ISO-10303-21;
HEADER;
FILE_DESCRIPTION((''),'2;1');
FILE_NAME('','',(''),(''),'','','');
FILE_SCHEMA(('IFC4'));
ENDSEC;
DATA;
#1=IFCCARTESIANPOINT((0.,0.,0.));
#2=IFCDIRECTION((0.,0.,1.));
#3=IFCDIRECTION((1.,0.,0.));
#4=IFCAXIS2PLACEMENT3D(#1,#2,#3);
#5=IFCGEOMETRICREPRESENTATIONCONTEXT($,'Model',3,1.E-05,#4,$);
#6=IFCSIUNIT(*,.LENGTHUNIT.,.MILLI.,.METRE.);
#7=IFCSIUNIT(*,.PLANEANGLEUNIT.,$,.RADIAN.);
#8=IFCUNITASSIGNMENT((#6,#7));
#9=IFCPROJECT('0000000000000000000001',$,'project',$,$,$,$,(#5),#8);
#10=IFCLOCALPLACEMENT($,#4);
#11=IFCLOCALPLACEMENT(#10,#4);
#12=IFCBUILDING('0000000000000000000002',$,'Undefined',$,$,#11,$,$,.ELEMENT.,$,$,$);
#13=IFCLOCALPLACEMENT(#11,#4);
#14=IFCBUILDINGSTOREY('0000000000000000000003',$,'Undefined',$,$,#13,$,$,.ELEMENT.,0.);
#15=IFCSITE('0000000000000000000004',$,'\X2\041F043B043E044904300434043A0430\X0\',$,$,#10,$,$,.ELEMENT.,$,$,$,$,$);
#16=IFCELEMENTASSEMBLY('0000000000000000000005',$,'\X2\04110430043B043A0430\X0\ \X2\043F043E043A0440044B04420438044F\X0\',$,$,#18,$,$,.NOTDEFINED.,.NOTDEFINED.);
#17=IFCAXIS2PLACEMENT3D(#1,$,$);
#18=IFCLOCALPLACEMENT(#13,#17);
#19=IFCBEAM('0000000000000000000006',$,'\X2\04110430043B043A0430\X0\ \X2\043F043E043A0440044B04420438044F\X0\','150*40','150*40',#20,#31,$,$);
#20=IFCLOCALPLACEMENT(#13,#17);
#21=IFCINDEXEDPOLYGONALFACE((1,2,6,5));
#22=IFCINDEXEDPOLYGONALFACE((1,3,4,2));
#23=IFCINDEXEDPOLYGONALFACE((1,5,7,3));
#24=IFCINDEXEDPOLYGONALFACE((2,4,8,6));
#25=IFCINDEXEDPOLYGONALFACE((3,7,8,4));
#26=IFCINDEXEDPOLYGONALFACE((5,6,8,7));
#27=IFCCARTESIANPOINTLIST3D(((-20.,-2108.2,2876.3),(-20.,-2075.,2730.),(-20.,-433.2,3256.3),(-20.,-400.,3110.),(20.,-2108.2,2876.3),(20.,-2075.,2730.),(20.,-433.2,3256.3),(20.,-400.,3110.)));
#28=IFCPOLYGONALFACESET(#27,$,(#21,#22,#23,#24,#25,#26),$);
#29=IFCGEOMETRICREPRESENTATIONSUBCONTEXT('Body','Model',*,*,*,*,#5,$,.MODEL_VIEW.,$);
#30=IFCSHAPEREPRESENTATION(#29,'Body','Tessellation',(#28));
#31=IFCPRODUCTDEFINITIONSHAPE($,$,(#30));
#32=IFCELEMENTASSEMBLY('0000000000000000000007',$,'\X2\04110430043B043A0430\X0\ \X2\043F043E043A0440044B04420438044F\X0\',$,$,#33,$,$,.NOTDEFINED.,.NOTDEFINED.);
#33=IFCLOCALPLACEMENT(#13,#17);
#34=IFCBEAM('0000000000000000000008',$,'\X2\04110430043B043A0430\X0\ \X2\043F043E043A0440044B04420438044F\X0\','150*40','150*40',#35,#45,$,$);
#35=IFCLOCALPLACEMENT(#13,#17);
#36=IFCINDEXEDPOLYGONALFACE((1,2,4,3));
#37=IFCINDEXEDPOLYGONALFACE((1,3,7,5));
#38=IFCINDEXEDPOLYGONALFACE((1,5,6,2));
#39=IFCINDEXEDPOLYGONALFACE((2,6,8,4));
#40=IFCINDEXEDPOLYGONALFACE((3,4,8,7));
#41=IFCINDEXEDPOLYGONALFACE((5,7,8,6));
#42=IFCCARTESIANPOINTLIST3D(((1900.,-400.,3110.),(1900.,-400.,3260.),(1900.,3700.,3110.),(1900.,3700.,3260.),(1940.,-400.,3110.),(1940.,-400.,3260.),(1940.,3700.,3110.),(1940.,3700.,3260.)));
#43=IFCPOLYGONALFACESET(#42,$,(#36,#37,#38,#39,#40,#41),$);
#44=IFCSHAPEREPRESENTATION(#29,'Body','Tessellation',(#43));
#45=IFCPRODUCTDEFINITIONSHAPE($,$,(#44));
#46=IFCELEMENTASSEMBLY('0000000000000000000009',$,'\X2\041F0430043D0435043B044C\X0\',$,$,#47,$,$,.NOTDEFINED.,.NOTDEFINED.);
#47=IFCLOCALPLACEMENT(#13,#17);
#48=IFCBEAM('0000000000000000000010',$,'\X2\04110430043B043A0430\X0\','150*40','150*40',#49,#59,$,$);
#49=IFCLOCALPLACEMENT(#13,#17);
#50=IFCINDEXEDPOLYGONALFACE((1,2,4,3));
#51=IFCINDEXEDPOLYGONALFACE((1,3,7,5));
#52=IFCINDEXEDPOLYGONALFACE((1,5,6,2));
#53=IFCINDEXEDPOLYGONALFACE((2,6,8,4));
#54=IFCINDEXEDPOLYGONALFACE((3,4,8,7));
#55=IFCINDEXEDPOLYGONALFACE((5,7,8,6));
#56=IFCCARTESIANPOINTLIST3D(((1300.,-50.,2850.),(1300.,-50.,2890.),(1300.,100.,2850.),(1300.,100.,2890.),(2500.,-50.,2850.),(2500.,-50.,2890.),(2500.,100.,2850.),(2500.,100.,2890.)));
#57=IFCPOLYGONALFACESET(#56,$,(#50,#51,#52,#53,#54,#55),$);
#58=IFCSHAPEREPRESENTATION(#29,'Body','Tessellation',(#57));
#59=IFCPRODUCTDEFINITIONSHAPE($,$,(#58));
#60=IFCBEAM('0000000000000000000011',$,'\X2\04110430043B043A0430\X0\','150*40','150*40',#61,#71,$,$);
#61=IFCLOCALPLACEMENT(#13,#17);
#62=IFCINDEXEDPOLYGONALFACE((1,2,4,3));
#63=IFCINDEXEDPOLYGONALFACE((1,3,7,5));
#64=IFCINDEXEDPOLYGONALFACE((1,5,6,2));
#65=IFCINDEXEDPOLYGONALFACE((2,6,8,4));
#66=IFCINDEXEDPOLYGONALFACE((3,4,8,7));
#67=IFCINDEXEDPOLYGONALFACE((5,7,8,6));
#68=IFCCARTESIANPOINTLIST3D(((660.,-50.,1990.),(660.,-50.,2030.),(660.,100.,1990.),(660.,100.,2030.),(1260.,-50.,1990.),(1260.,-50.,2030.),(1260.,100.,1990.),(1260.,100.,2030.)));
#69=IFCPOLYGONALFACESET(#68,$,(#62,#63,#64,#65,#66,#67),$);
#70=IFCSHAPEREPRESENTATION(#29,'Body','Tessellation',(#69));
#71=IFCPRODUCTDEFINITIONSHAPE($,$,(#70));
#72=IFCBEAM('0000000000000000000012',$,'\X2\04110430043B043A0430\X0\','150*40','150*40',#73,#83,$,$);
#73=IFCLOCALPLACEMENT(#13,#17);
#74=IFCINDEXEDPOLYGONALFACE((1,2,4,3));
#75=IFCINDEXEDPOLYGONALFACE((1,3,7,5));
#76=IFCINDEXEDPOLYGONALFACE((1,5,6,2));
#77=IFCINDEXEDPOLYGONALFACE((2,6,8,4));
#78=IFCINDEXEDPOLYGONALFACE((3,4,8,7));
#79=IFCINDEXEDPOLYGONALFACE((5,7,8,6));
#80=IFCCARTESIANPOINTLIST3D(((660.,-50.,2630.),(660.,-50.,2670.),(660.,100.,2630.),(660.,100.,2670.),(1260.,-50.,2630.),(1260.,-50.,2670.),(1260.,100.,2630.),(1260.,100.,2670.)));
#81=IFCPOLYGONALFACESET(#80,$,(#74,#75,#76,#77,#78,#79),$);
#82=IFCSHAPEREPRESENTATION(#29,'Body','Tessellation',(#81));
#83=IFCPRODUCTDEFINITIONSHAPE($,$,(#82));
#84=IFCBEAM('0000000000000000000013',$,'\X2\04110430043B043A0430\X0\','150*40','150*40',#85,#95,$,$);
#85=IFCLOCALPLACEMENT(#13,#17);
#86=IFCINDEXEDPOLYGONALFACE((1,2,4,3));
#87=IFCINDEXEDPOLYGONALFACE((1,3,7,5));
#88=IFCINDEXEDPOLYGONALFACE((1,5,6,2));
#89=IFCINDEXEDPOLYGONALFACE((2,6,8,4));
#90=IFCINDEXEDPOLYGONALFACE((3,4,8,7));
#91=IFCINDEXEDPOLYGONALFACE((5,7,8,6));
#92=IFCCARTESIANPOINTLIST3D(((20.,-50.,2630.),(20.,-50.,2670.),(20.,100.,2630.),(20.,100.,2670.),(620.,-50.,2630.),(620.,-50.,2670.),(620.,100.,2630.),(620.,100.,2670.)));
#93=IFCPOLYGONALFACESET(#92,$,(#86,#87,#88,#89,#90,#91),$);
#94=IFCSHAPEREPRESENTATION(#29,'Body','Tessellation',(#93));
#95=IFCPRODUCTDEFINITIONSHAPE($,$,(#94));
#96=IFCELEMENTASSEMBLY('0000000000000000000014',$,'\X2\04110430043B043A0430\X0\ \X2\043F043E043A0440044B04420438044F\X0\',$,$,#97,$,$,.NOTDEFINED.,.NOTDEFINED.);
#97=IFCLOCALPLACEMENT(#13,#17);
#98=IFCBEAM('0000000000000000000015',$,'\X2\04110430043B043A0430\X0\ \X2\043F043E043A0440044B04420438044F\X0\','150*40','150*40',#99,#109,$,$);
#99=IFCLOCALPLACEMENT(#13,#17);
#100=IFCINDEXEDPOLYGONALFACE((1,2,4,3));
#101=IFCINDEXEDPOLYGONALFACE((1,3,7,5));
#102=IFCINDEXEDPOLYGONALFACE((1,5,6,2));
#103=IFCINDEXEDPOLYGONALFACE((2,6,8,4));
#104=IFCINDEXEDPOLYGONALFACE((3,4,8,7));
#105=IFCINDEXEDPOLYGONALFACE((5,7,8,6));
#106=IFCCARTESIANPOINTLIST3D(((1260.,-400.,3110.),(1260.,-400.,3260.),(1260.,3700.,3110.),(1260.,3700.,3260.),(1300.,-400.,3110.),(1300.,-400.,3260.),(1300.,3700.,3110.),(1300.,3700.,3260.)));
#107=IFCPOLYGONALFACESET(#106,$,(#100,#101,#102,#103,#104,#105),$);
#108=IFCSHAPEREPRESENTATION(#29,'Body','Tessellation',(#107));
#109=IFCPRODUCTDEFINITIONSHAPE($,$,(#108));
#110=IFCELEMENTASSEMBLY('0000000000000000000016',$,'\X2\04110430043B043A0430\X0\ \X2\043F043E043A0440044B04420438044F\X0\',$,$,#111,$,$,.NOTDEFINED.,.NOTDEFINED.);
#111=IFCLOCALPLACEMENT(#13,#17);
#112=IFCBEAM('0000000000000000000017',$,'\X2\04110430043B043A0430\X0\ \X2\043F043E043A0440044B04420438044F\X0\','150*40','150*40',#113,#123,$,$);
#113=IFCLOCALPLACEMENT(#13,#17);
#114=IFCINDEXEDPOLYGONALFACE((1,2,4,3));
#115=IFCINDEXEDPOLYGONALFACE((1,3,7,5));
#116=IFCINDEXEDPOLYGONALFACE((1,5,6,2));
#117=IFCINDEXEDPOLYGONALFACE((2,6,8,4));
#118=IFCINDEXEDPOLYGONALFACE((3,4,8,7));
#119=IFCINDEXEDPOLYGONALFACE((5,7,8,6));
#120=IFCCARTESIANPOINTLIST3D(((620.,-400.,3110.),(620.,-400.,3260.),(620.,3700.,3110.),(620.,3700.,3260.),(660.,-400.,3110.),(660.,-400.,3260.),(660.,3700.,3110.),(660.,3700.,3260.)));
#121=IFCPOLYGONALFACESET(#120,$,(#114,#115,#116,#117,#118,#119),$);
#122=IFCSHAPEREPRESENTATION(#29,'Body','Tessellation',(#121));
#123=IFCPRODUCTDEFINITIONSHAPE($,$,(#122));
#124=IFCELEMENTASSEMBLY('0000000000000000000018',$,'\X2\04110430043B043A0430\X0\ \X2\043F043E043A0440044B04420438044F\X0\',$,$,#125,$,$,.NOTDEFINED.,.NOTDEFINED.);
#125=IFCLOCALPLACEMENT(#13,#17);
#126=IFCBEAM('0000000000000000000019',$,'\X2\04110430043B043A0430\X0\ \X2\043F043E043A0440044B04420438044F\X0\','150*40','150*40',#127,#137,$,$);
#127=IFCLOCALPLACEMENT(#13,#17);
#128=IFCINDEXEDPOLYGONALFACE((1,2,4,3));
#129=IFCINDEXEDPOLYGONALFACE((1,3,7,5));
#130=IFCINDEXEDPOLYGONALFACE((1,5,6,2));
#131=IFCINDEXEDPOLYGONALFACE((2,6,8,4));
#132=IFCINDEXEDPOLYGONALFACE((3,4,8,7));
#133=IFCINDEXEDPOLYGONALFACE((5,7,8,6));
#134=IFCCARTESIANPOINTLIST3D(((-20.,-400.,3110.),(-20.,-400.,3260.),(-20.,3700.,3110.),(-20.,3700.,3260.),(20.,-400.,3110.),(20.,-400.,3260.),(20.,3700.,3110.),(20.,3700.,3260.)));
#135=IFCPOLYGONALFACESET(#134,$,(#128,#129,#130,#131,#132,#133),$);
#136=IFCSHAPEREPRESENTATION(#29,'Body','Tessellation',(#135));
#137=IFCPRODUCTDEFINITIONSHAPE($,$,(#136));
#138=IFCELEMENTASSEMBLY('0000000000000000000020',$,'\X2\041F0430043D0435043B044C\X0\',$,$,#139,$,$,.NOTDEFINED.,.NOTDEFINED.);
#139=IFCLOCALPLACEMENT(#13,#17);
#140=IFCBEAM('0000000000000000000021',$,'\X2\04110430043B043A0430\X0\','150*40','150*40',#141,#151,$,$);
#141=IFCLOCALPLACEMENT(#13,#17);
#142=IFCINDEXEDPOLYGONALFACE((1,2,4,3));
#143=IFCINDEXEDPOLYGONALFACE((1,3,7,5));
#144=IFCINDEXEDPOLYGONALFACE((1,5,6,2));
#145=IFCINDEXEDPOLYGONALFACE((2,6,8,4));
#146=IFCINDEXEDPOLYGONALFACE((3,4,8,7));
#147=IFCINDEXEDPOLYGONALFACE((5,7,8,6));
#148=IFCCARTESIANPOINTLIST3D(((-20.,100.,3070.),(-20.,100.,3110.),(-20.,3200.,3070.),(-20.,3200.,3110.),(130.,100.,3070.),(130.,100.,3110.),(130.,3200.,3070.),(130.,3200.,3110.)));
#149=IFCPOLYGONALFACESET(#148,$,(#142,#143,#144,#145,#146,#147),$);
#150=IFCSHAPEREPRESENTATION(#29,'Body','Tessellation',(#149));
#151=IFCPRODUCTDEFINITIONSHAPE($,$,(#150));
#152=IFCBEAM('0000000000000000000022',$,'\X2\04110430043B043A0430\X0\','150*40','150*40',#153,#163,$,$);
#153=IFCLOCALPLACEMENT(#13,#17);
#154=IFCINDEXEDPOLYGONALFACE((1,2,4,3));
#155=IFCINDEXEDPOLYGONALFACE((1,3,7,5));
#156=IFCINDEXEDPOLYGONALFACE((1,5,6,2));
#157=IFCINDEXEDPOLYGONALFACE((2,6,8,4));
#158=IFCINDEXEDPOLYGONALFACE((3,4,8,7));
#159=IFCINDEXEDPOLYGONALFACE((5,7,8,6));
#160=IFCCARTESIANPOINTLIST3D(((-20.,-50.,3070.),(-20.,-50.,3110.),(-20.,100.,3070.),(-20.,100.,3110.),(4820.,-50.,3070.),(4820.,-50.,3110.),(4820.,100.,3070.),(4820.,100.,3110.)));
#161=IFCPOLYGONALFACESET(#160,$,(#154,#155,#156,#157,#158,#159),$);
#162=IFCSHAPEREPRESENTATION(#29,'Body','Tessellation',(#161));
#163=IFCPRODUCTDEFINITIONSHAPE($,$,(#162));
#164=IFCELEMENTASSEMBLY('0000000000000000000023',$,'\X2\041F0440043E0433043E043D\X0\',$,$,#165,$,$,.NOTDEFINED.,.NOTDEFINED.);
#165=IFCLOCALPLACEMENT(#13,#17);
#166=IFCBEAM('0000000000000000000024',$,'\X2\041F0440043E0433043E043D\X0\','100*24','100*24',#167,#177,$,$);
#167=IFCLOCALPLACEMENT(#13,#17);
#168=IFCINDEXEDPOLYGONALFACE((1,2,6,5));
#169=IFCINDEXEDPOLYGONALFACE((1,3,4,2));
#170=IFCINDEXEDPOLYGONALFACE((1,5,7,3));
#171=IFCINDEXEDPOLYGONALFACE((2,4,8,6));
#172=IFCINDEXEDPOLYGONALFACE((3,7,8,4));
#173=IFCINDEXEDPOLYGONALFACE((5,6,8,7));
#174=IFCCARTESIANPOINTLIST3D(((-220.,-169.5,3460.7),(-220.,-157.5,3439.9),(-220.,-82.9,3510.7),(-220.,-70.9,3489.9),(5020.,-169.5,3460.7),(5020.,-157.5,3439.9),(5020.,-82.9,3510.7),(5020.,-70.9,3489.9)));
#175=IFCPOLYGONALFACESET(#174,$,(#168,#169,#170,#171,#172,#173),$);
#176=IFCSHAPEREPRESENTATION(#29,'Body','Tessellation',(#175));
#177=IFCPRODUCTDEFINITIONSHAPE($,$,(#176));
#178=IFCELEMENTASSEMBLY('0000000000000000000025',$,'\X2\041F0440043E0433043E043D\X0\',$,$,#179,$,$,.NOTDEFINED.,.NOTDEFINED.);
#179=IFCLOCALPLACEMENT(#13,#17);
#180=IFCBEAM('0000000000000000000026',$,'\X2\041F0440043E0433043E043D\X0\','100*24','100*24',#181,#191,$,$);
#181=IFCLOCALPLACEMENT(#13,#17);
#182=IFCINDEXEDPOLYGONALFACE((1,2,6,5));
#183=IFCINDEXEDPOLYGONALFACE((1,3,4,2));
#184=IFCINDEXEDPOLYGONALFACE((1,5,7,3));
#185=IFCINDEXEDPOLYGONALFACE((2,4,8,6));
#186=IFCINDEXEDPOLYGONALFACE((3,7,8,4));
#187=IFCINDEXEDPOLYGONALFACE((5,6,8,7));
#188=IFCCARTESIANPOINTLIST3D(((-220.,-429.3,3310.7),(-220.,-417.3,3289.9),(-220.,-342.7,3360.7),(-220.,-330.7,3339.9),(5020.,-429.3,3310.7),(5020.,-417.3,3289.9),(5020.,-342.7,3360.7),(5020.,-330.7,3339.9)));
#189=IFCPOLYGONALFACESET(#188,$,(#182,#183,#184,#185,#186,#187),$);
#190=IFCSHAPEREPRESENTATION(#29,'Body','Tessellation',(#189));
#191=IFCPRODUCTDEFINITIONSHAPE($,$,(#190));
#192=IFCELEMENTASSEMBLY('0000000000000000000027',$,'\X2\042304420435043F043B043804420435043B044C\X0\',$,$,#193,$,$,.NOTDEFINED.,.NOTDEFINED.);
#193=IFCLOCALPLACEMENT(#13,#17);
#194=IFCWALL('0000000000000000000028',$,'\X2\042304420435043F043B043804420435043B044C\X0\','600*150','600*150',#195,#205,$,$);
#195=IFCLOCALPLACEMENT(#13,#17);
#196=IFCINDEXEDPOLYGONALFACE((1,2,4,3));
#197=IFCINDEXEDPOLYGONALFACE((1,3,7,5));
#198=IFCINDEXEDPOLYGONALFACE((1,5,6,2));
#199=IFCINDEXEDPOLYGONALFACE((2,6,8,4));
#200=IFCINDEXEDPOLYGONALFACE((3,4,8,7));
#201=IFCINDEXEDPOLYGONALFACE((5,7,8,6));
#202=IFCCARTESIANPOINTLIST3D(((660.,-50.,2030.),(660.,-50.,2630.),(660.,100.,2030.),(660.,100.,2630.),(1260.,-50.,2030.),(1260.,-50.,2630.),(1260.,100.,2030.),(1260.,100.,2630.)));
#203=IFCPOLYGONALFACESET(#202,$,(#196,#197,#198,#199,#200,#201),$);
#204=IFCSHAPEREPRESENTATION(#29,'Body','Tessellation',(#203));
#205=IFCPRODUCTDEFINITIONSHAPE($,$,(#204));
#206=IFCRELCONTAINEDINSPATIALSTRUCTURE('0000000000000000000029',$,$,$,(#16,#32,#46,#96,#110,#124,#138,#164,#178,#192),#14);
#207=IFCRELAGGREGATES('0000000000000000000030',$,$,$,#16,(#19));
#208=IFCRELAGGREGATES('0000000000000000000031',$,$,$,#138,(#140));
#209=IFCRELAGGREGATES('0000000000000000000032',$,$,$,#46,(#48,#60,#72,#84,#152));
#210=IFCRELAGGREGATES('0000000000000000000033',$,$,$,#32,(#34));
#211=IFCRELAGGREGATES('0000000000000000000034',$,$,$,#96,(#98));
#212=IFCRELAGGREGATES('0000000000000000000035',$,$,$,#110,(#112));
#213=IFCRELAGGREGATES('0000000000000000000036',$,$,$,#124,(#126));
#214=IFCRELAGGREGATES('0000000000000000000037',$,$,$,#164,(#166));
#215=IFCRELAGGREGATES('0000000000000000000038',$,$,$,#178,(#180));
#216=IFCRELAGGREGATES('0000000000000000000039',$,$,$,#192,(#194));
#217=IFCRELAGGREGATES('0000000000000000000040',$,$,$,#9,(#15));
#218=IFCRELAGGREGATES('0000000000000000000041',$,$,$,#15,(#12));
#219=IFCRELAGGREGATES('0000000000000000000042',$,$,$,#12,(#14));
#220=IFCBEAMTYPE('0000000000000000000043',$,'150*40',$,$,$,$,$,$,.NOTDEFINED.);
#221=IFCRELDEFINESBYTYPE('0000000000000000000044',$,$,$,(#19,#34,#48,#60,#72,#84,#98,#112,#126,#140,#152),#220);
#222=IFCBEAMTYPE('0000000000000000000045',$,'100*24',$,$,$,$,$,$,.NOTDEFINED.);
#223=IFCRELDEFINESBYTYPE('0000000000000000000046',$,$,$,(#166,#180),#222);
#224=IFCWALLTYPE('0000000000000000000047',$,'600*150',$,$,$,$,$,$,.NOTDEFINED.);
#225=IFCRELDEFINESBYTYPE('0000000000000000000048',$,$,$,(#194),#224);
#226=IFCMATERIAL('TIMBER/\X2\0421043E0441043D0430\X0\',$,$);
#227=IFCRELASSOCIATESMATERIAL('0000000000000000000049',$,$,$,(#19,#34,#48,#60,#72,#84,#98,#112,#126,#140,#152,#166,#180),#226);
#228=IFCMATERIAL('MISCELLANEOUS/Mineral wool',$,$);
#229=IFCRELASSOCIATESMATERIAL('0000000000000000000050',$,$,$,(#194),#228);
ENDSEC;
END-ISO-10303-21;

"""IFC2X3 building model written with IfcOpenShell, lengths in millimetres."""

from ifc_helpers import new_model, si_unit, frame, frame_2d, origin_with_axes, origin_2d_with_axis, place, context, subcontext, project, spatial, rectangle, extrude, material, type_object, element, aggregate, save


model = new_model("IFC2X3")

# Units and contexts
model_context = context("Model", 3, precision=1e-05, world=origin_with_axes())
body_context = subcontext(model_context, "Body", "Model", "MODEL_VIEW")
ifc_project = project(units=[si_unit("LENGTHUNIT", "METRE", prefix="MILLI"), si_unit("PLANEANGLEUNIT", "RADIAN")], contexts=[model_context])

# Site, building, storey
site_placement = place(None, origin_with_axes())
site = spatial("IfcSite", under=ifc_project, at=site_placement, Name="Площадка", CompositionType="ELEMENT")
building_placement = place(site_placement, origin_with_axes())
building = spatial("IfcBuilding", under=site, at=building_placement, Name="Undefined", CompositionType="ELEMENT")
storey_placement = place(building_placement, origin_with_axes())
storey = spatial("IfcBuildingStorey", under=building, at=storey_placement, Name="Undefined", CompositionType="ELEMENT", Elevation=0.0)

# Element assemblies, beams
assembly_1_placement = place(storey_placement, origin_with_axes())
assembly_1 = element("IfcElementAssembly", 1, at=assembly_1_placement, inside=storey, Name="Балка покрытия", AssemblyPlace="NOTDEFINED", PredefinedType="NOTDEFINED")
ifc_material_1 = material(Name="TIMBER/Сосна")
beam_type_1 = type_object("IfcBeamType", Name="150*40", PredefinedType="NOTDEFINED")
beam_1_placement = place(assembly_1_placement, frame((0.0, -2091.6, 2803.1), z_axis=(0.0, 0.221244, -0.975219), x_axis=(0.0, 0.975219, 0.221244)))
beam_1 = element("IfcBeam", 2, at=beam_1_placement, type_object=beam_type_1, material=ifc_material_1, Name="Балка покрытия", Description="150*40", ObjectType="150*40", context=body_context, shape_type="SweptSolid", body=[
    extrude(rectangle(XDim=40.0, YDim=150.0, at=origin_2d_with_axis()), frame((1717.6, 0.0, 0.0), z_axis=(-1.0, 0.0, 0.0), x_axis=(0.0, -1.0, 0.0)), (0.0, 0.0, 1.0), 1717.6),
])
aggregate(assembly_1, [beam_1])
assembly_2_placement = place(storey_placement, origin_with_axes())
assembly_2 = element("IfcElementAssembly", 3, at=assembly_2_placement, inside=storey, Name="Балка покрытия", AssemblyPlace="NOTDEFINED", PredefinedType="NOTDEFINED")
beam_2_placement = place(assembly_2_placement, frame((1920.0, -400.0, 3185.0), z_axis=(0.0, 0.0, -1.0), x_axis=(0.0, 1.0, 0.0)))
beam_2 = element("IfcBeam", 4, at=beam_2_placement, type_object=beam_type_1, material=ifc_material_1, Name="Балка покрытия", Description="150*40", ObjectType="150*40", context=body_context, shape_type="SweptSolid", body=[
    extrude(rectangle(XDim=40.0, YDim=150.0, at=origin_2d_with_axis()), frame((4100.0, 0.0, 0.0), z_axis=(-1.0, 0.0, 0.0), x_axis=(0.0, -1.0, 0.0)), (0.0, 0.0, 1.0), 4100.0),
])

# Element assembly, beams
assembly_3_placement = place(storey_placement, origin_with_axes())
assembly_3 = element("IfcElementAssembly", 5, at=assembly_3_placement, inside=storey, Name="Панель", AssemblyPlace="NOTDEFINED", PredefinedType="NOTDEFINED")
beam_3_placement = place(assembly_3_placement, frame((1300.0, 25.0, 2870.0), z_axis=(0.0, 1.0, 0.0), x_axis=(1.0, 0.0, 0.0)))
beam_3 = element("IfcBeam", 6, at=beam_3_placement, type_object=beam_type_1, material=ifc_material_1, Name="Балка", Description="150*40", ObjectType="150*40", context=body_context, shape_type="SweptSolid", body=[
    extrude(rectangle(XDim=40.0, YDim=150.0, at=origin_2d_with_axis()), frame((1200.0, 0.0, 0.0), z_axis=(-1.0, 0.0, 0.0), x_axis=(0.0, -1.0, 0.0)), (0.0, 0.0, 1.0), 1200.0),
])
beam_4_placement = place(assembly_3_placement, frame((660.0, 25.0, 2010.0), z_axis=(0.0, 1.0, 0.0), x_axis=(1.0, 0.0, 0.0)))
beam_4 = element("IfcBeam", 7, at=beam_4_placement, type_object=beam_type_1, material=ifc_material_1, Name="Балка", Description="150*40", ObjectType="150*40", context=body_context, shape_type="SweptSolid", body=[
    extrude(rectangle(XDim=40.0, YDim=150.0, at=origin_2d_with_axis()), frame((600.0, 0.0, 0.0), z_axis=(-1.0, 0.0, 0.0), x_axis=(0.0, -1.0, 0.0)), (0.0, 0.0, 1.0), 600.0),
])
beam_5_placement = place(assembly_3_placement, frame((660.0, 25.0, 2650.0), z_axis=(0.0, 1.0, 0.0), x_axis=(1.0, 0.0, 0.0)))
beam_5 = element("IfcBeam", 8, at=beam_5_placement, type_object=beam_type_1, material=ifc_material_1, Name="Балка", Description="150*40", ObjectType="150*40", context=body_context, shape_type="SweptSolid", body=[
    extrude(rectangle(XDim=40.0, YDim=150.0, at=origin_2d_with_axis()), frame((600.0, 0.0, 0.0), z_axis=(-1.0, 0.0, 0.0), x_axis=(0.0, -1.0, 0.0)), (0.0, 0.0, 1.0), 600.0),
])
beam_6_placement = place(assembly_3_placement, frame((20.0, 25.0, 2650.0), z_axis=(0.0, 1.0, 0.0), x_axis=(1.0, 0.0, 0.0)))
beam_6 = element("IfcBeam", 9, at=beam_6_placement, type_object=beam_type_1, material=ifc_material_1, Name="Балка", Description="150*40", ObjectType="150*40", context=body_context, shape_type="SweptSolid", body=[
    extrude(rectangle(XDim=40.0, YDim=150.0, at=origin_2d_with_axis()), frame((600.0, 0.0, 0.0), z_axis=(-1.0, 0.0, 0.0), x_axis=(0.0, -1.0, 0.0)), (0.0, 0.0, 1.0), 600.0),
])

# Element assemblies, beams
assembly_4_placement = place(storey_placement, origin_with_axes())
assembly_4 = element("IfcElementAssembly", 10, at=assembly_4_placement, inside=storey, Name="Балка покрытия", AssemblyPlace="NOTDEFINED", PredefinedType="NOTDEFINED")
beam_7_placement = place(assembly_4_placement, frame((1280.0, -400.0, 3185.0), z_axis=(0.0, 0.0, -1.0), x_axis=(0.0, 1.0, 0.0)))
beam_7 = element("IfcBeam", 11, at=beam_7_placement, type_object=beam_type_1, material=ifc_material_1, Name="Балка покрытия", Description="150*40", ObjectType="150*40", context=body_context, shape_type="SweptSolid", body=[
    extrude(rectangle(XDim=40.0, YDim=150.0, at=origin_2d_with_axis()), frame((4100.0, 0.0, 0.0), z_axis=(-1.0, 0.0, 0.0), x_axis=(0.0, -1.0, 0.0)), (0.0, 0.0, 1.0), 4100.0),
])
assembly_5_placement = place(storey_placement, origin_with_axes())
assembly_5 = element("IfcElementAssembly", 12, at=assembly_5_placement, inside=storey, Name="Балка покрытия", AssemblyPlace="NOTDEFINED", PredefinedType="NOTDEFINED")
beam_8_placement = place(assembly_5_placement, frame((640.0, -400.0, 3185.0), z_axis=(0.0, 0.0, -1.0), x_axis=(0.0, 1.0, 0.0)))
beam_8 = element("IfcBeam", 13, at=beam_8_placement, type_object=beam_type_1, material=ifc_material_1, Name="Балка покрытия", Description="150*40", ObjectType="150*40", context=body_context, shape_type="SweptSolid", body=[
    extrude(rectangle(XDim=40.0, YDim=150.0, at=origin_2d_with_axis()), frame((4100.0, 0.0, 0.0), z_axis=(-1.0, 0.0, 0.0), x_axis=(0.0, -1.0, 0.0)), (0.0, 0.0, 1.0), 4100.0),
])
assembly_6_placement = place(storey_placement, origin_with_axes())
assembly_6 = element("IfcElementAssembly", 14, at=assembly_6_placement, inside=storey, Name="Балка покрытия", AssemblyPlace="NOTDEFINED", PredefinedType="NOTDEFINED")
beam_9_placement = place(assembly_6_placement, frame((0.0, -400.0, 3185.0), z_axis=(0.0, 0.0, -1.0), x_axis=(0.0, 1.0, 0.0)))
beam_9 = element("IfcBeam", 15, at=beam_9_placement, type_object=beam_type_1, material=ifc_material_1, Name="Балка покрытия", Description="150*40", ObjectType="150*40", context=body_context, shape_type="SweptSolid", body=[
    extrude(rectangle(XDim=40.0, YDim=150.0, at=origin_2d_with_axis()), frame((4100.0, 0.0, 0.0), z_axis=(-1.0, 0.0, 0.0), x_axis=(0.0, -1.0, 0.0)), (0.0, 0.0, 1.0), 4100.0),
])
assembly_7_placement = place(storey_placement, origin_with_axes())
assembly_7 = element("IfcElementAssembly", 16, at=assembly_7_placement, inside=storey, Name="Панель", AssemblyPlace="NOTDEFINED", PredefinedType="NOTDEFINED")
beam_10_placement = place(assembly_7_placement, frame((55.0, 100.0, 3090.0), z_axis=(-1.0, 0.0, 0.0), x_axis=(0.0, 1.0, 0.0)))
beam_10 = element("IfcBeam", 17, at=beam_10_placement, type_object=beam_type_1, material=ifc_material_1, Name="Балка", Description="150*40", ObjectType="150*40", context=body_context, shape_type="SweptSolid", body=[
    extrude(rectangle(XDim=40.0, YDim=150.0, at=origin_2d_with_axis()), frame((3100.0, 0.0, 0.0), z_axis=(-1.0, 0.0, 0.0), x_axis=(0.0, -1.0, 0.0)), (0.0, 0.0, 1.0), 3100.0),
])
aggregate(assembly_7, [beam_10])

# Beam
beam_11_placement = place(assembly_3_placement, frame((-20.0, 25.0, 3090.0), z_axis=(0.0, 1.0, 0.0), x_axis=(1.0, 0.0, 0.0)))
beam_11 = element("IfcBeam", 18, at=beam_11_placement, type_object=beam_type_1, material=ifc_material_1, Name="Балка", Description="150*40", ObjectType="150*40", context=body_context, shape_type="SweptSolid", body=[
    extrude(rectangle(XDim=40.0, YDim=150.0, at=origin_2d_with_axis()), frame((4840.0, 0.0, 0.0), z_axis=(-1.0, 0.0, 0.0), x_axis=(0.0, -1.0, 0.0)), (0.0, 0.0, 1.0), 4840.0),
])
aggregate(assembly_3, [beam_3, beam_4, beam_5, beam_6, beam_11])

aggregate(assembly_2, [beam_2])
aggregate(assembly_4, [beam_7])
aggregate(assembly_5, [beam_8])
aggregate(assembly_6, [beam_9])

# Element assemblies, beams
assembly_8_placement = place(storey_placement, origin_with_axes())
assembly_8 = element("IfcElementAssembly", 19, at=assembly_8_placement, inside=storey, Name="Прогон", AssemblyPlace="NOTDEFINED", PredefinedType="NOTDEFINED")
beam_type_2 = type_object("IfcBeamType", Name="100*24", PredefinedType="NOTDEFINED")
beam_12_placement = place(assembly_8_placement, frame((-220.0, -120.2, 3475.3), z_axis=(0.0, 0.866025, 0.5), x_axis=(1.0, 0.0, 0.0)))
beam_12 = element("IfcBeam", 20, at=beam_12_placement, type_object=beam_type_2, material=ifc_material_1, Name="Прогон", Description="100*24", ObjectType="100*24", context=body_context, shape_type="SweptSolid", body=[
    extrude(rectangle(XDim=24.0, YDim=100.0, at=origin_2d_with_axis()), frame((5240.0, 0.0, 0.0), z_axis=(-1.0, 0.0, 0.0), x_axis=(0.0, -1.0, 0.0)), (0.0, 0.0, 1.0), 5240.0),
])
aggregate(assembly_8, [beam_12])
assembly_9_placement = place(storey_placement, origin_with_axes())
assembly_9 = element("IfcElementAssembly", 21, at=assembly_9_placement, inside=storey, Name="Прогон", AssemblyPlace="NOTDEFINED", PredefinedType="NOTDEFINED")
beam_13_placement = place(assembly_9_placement, frame((-220.0, -380.0, 3325.3), z_axis=(0.0, 0.866025, 0.5), x_axis=(1.0, 0.0, 0.0)))
beam_13 = element("IfcBeam", 22, at=beam_13_placement, type_object=beam_type_2, material=ifc_material_1, Name="Прогон", Description="100*24", ObjectType="100*24", context=body_context, shape_type="SweptSolid", body=[
    extrude(rectangle(XDim=24.0, YDim=100.0, at=origin_2d_with_axis()), frame((5240.0, 0.0, 0.0), z_axis=(-1.0, 0.0, 0.0), x_axis=(0.0, -1.0, 0.0)), (0.0, 0.0, 1.0), 5240.0),
])
aggregate(assembly_9, [beam_13])

# Element assembly, wall
assembly_10_placement = place(storey_placement, origin_with_axes())
assembly_10 = element("IfcElementAssembly", 23, at=assembly_10_placement, inside=storey, Name="Утеплитель", AssemblyPlace="NOTDEFINED", PredefinedType="NOTDEFINED")
ifc_material_2 = material(Name="MISCELLANEOUS/Mineral wool")
wall_type_1 = type_object("IfcWallType", Name="600*150", PredefinedType="NOTDEFINED")
wall_1_placement = place(assembly_10_placement, frame((660.0, 25.0, 2030.0), z_axis=(0.0, 0.0, 1.0), x_axis=(1.0, 0.0, 0.0)))
wall_1 = element("IfcWall", 24, at=wall_1_placement, type_object=wall_type_1, material=ifc_material_2, Name="Утеплитель", Description="600*150", ObjectType="600*150", context=body_context, shape_type="SweptSolid", body=[
    extrude(rectangle(XDim=600.0, YDim=150.0, at=frame_2d((0.0, 300.0), x_axis=(0.0, -1.0))), frame((0.0, 0.0, 0.0), z_axis=(0.0, 0.0, 1.0), x_axis=(0.0, -1.0, 0.0)), (0.0, 0.0, 1.0), 600.0),
])
aggregate(assembly_10, [wall_1])

save(model, "model.ifc")
